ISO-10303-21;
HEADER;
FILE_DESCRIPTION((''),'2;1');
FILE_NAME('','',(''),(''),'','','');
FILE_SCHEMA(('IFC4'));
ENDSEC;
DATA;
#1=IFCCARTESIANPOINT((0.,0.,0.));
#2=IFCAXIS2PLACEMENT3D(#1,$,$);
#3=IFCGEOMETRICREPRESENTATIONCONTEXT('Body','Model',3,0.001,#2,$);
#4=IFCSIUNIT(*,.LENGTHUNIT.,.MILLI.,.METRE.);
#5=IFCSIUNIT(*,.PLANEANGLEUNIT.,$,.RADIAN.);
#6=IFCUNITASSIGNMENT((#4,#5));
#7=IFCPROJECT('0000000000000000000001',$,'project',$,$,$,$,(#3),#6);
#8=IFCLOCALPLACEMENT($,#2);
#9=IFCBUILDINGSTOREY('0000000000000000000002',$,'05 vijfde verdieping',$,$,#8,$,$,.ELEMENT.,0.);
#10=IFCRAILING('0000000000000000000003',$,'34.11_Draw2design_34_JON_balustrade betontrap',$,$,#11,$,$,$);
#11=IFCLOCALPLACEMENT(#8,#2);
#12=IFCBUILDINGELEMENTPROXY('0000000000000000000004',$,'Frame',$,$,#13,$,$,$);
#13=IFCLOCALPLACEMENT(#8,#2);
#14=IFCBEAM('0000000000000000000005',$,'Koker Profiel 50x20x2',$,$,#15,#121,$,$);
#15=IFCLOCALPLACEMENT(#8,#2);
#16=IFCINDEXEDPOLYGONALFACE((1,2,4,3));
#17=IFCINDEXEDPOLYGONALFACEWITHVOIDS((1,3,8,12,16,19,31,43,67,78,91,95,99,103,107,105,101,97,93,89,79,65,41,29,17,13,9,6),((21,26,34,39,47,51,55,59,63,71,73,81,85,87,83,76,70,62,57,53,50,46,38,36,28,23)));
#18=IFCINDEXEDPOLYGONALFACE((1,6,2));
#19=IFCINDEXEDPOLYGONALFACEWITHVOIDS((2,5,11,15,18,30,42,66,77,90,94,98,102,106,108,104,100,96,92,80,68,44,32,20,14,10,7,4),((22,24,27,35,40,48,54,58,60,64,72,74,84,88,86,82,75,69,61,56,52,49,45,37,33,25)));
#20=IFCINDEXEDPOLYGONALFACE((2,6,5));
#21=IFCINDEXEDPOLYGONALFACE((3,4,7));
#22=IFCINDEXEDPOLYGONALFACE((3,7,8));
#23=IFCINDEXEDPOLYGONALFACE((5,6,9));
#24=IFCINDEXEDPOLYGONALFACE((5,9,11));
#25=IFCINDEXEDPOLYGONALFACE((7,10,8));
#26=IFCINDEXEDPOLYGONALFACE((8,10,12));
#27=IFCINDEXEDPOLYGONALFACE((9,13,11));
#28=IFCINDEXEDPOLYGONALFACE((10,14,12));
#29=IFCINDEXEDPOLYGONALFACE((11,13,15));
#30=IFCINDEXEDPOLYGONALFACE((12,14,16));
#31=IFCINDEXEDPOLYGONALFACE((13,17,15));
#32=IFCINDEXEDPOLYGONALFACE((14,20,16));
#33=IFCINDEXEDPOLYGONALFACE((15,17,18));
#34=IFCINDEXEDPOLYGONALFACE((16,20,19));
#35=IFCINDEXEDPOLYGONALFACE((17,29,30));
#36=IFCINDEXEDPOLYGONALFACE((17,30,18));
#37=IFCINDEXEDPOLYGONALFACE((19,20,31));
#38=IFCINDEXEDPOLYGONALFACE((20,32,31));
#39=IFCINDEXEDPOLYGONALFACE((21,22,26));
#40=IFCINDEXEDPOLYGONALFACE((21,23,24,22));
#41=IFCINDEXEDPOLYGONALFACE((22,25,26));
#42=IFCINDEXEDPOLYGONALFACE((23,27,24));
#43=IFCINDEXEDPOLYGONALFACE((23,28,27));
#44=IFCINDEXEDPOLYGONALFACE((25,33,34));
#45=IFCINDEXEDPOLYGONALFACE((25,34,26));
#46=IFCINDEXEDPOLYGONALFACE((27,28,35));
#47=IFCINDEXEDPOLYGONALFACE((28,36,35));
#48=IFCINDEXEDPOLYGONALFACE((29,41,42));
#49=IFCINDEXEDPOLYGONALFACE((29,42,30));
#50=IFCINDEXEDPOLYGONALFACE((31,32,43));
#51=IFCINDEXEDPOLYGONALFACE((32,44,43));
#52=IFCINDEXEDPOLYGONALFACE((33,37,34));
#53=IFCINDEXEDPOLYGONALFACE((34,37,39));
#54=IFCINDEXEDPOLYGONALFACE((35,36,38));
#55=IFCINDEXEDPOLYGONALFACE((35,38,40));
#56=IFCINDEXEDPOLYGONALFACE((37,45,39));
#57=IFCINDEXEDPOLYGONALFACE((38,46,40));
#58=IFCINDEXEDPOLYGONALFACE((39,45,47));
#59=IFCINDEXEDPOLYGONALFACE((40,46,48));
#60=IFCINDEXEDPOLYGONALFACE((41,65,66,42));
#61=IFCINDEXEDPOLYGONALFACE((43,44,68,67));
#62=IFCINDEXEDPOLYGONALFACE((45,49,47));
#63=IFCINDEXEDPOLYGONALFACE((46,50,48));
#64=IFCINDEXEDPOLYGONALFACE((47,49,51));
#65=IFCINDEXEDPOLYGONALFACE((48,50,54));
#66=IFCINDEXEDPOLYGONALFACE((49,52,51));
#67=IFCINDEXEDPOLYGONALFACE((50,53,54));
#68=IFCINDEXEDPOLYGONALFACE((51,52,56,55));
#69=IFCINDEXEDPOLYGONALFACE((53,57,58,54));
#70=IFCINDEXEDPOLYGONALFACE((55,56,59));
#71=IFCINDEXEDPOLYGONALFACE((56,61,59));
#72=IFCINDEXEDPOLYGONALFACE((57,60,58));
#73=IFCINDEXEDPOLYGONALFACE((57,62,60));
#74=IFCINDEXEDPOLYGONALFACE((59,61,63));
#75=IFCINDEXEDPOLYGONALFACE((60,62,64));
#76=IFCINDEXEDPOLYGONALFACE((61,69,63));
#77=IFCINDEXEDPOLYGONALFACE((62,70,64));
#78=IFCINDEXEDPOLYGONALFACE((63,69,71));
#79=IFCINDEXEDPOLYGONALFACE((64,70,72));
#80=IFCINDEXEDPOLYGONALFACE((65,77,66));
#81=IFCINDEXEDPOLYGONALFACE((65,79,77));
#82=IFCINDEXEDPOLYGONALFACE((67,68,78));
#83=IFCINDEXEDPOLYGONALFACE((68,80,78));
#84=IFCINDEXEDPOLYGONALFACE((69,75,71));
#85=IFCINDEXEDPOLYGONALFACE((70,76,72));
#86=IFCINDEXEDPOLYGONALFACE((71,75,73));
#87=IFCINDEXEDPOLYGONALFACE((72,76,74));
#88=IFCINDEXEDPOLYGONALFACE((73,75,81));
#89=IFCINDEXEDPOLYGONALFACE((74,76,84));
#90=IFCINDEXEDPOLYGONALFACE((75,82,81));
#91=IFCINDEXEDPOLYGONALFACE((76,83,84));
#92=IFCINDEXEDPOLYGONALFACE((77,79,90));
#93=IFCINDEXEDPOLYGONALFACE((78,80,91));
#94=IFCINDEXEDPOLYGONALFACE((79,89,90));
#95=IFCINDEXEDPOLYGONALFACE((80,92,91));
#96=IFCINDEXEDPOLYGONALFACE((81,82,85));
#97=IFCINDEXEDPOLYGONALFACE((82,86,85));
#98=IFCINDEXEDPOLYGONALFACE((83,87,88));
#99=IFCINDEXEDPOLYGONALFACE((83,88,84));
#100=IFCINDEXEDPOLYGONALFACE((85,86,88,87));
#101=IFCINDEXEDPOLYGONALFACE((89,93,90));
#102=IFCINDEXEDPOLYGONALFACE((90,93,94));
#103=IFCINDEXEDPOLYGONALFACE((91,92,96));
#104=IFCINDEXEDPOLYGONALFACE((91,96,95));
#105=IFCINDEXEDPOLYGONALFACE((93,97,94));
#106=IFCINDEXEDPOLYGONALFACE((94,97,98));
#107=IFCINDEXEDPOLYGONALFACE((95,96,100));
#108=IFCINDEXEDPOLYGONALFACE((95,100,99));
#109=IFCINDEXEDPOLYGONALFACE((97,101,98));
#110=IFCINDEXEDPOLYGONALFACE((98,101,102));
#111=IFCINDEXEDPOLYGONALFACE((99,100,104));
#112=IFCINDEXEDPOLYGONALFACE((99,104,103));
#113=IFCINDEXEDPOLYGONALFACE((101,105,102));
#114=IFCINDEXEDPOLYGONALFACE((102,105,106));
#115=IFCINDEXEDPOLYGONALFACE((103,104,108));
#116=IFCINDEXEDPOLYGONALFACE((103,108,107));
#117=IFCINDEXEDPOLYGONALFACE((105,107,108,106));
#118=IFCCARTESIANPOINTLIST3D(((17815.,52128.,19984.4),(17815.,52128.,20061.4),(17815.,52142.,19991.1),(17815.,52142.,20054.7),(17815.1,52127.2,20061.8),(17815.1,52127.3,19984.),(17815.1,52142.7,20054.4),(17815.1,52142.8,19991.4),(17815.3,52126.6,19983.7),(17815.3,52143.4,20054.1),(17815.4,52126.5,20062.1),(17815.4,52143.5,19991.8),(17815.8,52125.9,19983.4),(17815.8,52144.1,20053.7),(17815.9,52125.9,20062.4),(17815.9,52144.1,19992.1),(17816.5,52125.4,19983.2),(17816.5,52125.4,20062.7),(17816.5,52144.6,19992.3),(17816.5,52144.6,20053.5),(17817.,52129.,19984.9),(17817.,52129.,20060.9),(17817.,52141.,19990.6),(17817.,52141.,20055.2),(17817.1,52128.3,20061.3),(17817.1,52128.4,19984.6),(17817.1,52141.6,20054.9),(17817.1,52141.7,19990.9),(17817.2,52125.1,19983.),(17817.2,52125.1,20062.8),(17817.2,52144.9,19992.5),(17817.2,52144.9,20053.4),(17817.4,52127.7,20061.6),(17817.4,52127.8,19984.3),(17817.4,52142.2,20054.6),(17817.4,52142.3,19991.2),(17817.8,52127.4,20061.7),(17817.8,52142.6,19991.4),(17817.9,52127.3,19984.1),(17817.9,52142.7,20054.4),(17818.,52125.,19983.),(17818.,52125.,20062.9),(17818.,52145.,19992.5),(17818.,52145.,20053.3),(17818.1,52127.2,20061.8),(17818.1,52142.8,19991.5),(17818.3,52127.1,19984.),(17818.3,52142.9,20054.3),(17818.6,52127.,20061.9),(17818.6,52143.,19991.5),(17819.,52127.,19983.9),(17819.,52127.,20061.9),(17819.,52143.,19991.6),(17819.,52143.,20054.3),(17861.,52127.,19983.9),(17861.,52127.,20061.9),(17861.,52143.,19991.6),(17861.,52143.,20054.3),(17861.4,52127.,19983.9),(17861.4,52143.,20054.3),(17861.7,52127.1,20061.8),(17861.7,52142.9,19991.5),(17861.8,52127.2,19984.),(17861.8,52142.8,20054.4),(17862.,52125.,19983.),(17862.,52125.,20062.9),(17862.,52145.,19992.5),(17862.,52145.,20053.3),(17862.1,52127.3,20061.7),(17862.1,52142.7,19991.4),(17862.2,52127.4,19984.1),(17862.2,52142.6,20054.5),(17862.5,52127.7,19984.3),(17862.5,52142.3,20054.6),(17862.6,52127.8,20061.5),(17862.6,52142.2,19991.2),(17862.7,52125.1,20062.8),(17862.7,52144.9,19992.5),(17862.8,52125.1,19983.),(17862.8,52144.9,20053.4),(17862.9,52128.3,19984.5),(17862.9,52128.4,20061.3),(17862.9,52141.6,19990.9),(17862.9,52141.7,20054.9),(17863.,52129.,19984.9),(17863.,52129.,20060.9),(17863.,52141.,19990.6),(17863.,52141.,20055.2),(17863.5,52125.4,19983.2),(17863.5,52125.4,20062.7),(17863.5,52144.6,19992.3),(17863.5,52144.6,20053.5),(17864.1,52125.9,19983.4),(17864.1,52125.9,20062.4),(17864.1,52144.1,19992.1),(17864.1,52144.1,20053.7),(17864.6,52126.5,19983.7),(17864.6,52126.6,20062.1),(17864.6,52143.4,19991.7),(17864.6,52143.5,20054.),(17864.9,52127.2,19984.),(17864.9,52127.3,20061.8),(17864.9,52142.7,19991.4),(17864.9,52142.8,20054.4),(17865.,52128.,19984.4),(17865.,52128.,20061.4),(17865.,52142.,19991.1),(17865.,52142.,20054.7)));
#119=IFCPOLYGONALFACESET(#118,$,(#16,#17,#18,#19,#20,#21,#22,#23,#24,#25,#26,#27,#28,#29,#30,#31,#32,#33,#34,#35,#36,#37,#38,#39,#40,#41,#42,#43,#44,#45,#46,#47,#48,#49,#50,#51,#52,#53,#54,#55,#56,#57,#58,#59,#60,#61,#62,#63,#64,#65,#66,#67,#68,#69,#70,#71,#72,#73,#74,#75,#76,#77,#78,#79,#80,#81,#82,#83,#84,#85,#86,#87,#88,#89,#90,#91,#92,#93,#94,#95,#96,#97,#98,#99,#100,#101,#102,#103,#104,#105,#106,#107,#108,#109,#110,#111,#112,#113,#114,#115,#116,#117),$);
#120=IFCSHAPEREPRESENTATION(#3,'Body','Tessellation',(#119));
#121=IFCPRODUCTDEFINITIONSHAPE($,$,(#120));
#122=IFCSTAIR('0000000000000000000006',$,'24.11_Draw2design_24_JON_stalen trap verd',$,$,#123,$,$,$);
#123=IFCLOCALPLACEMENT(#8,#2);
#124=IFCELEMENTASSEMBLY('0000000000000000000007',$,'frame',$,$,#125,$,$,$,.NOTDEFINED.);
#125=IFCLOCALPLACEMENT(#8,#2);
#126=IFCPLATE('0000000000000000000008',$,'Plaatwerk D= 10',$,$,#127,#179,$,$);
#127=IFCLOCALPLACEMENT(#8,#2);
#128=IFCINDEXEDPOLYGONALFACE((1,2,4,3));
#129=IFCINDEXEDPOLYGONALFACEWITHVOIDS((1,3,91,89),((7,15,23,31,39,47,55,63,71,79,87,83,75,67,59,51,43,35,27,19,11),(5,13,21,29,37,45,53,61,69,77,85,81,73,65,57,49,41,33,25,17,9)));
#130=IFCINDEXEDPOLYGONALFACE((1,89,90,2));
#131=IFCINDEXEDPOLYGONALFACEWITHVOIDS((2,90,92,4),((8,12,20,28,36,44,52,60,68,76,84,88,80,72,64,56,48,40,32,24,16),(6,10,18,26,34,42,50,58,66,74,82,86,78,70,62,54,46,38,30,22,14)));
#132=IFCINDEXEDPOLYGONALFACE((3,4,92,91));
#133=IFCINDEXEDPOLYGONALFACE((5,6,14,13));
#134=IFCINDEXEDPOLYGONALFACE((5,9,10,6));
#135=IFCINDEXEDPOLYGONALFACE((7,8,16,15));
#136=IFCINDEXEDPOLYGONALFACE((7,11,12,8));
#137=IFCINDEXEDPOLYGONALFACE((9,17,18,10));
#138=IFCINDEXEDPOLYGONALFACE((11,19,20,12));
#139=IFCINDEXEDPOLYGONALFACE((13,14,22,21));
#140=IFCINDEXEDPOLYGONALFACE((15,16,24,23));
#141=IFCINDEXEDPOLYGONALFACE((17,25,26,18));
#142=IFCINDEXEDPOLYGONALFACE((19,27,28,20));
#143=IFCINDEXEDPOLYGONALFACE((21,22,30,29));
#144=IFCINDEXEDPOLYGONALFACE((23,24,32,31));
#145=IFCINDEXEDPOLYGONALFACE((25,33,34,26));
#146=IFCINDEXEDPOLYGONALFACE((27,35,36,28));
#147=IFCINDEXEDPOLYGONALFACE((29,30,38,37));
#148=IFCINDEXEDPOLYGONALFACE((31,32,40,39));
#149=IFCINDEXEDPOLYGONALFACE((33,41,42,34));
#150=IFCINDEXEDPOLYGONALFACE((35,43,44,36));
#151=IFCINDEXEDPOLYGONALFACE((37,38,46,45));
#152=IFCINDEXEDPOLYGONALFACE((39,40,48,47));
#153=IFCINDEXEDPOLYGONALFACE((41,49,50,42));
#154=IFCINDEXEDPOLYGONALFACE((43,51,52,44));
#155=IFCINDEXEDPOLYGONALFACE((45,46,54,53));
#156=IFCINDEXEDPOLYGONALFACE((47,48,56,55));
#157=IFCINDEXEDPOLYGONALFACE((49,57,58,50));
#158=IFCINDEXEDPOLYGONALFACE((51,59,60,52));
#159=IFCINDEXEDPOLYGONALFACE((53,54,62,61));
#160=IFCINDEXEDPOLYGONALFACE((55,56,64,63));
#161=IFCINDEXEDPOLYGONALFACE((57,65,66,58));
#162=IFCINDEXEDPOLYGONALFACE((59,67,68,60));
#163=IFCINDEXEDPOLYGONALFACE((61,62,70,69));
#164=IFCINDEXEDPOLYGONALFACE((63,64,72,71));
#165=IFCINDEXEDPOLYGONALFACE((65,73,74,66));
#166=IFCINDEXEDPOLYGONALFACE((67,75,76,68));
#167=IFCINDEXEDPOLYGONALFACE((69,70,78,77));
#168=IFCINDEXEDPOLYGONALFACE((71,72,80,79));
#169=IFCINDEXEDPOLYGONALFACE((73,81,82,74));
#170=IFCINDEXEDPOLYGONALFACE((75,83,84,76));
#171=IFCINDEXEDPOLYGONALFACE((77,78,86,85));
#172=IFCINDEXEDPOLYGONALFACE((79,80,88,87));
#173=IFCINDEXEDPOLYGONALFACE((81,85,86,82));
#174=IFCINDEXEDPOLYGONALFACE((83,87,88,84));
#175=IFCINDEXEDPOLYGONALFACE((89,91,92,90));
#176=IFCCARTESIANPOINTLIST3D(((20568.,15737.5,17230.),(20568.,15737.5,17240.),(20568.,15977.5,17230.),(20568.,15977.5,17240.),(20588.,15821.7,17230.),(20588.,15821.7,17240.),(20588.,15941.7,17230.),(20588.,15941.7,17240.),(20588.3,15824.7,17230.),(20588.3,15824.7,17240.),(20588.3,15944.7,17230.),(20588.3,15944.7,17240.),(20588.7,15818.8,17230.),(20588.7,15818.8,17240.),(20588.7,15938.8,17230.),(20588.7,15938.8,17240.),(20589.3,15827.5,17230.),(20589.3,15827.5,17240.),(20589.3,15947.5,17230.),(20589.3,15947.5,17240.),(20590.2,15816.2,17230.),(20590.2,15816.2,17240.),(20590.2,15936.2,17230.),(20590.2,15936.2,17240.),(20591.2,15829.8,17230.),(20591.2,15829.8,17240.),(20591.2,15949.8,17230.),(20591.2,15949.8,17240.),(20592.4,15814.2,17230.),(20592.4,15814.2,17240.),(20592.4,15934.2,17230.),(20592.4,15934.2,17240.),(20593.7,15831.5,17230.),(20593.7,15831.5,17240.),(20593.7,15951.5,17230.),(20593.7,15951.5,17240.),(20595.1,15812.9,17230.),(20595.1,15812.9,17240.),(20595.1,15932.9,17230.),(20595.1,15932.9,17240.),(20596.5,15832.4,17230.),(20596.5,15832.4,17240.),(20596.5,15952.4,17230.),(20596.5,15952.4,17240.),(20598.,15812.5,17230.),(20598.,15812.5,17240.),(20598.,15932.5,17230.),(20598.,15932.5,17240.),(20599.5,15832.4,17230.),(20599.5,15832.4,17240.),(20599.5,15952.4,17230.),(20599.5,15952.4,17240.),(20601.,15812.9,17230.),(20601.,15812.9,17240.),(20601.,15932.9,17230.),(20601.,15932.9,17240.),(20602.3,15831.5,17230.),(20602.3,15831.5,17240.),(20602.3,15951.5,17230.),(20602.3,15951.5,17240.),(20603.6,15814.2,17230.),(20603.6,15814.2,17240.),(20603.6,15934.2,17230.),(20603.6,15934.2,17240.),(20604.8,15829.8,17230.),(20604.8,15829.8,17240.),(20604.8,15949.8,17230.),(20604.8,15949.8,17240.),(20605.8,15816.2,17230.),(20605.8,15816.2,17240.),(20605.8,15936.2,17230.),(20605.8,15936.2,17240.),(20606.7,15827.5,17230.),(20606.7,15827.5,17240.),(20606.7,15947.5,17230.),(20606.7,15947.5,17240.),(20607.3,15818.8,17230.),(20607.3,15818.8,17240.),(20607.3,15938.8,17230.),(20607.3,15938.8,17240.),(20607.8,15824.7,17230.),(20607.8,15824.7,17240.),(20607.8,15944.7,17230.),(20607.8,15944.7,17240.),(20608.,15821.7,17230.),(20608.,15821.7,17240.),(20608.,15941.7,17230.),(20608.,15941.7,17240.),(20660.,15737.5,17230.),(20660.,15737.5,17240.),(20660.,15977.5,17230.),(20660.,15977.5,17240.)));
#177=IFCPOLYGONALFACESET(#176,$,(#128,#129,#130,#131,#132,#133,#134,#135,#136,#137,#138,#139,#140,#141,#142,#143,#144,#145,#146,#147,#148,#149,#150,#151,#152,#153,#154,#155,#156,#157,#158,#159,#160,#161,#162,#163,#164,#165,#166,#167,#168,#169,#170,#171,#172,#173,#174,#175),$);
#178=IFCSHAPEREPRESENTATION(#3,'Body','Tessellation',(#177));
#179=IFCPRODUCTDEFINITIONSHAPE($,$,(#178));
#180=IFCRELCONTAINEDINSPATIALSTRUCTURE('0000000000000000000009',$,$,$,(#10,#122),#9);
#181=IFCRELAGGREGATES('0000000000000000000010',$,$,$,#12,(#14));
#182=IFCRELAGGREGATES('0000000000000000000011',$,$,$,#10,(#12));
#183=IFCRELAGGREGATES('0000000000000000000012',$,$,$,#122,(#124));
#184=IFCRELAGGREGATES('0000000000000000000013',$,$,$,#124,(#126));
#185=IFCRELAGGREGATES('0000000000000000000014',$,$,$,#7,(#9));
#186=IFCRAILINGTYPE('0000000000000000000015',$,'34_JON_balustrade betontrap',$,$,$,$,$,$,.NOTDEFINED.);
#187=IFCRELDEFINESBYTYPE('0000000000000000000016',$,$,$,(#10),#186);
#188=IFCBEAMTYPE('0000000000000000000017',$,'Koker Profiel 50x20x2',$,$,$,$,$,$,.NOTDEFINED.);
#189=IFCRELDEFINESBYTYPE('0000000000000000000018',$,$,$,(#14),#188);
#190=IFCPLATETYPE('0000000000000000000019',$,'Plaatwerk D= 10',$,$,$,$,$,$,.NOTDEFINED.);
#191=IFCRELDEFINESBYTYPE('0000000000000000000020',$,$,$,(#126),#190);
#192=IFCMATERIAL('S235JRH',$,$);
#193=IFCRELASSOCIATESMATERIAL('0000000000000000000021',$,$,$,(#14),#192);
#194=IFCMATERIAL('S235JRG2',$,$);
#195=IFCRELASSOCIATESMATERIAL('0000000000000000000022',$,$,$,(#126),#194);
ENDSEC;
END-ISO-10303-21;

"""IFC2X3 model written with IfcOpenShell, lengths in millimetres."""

from ifc_helpers import new_model, si_unit, frame, origin, origin_2d, place, context, project, spatial, rectangle, hollow_rectangle, circle, extrude, clip, halfspace, source, transform, mapped, material, type_object, element, aggregate, save


model = new_model("IFC2X3")

# Units and contexts
model_context = context("Model", 3, precision=0.001, world=origin(), identifier="Body")
ifc_project = project(units=[si_unit("LENGTHUNIT", "METRE", prefix="MILLI"), si_unit("PLANEANGLEUNIT", "RADIAN")], contexts=[model_context])

# Storey
storey_placement = place(None, origin())
storey = spatial("IfcBuildingStorey", under=ifc_project, at=storey_placement, Name="05 vijfde verdieping", CompositionType="ELEMENT", Elevation=0.0)

# Shared definitions
railing_type_1 = type_object("IfcRailingType", Name="34_JON_balustrade betontrap")
ifc_material_1 = material(Name="S235JRH")
ifc_material_2 = material(Name="S235JRG2")
beam_type_1 = type_object("IfcBeamType", Name="Koker Profiel 50x20x2")

# Railing, building element proxy
railing_1_placement = place(storey_placement, frame((38619.5, 98107.5, -28901.4), z_axis=(0.0, 0.0, 1.0), x_axis=(-1.0, 0.0, 0.0)))
railing_1 = element("IfcRailing", 1, at=railing_1_placement, inside=storey, type_object=railing_type_1, Name="34.11_Draw2design_34_JON_balustrade betontrap")
proxy_1_placement = place(railing_1_placement, origin())
proxy_1 = element("IfcBuildingElementProxy", 2, at=proxy_1_placement, Name="Frame")

# Beam
shared_shape_1 = source(origin(), model_context, "Body", "Clipping", [
    clip(clip(extrude(hollow_rectangle(XDim=20.0, YDim=50.0, WallThickness=2.0, InnerFilletRadius=2.0, OuterFilletRadius=3.0, at=origin_2d()), origin(), (0.0, 0.0, -1.0), 79.9), halfspace(frame((-10.0, 25.0, -9.6), z_axis=(-0.430948, 0.0, 0.902377), x_axis=(0.902377, 0.0, 0.430948)), False)), halfspace(frame((-10.0, -25.0, -70.3), z_axis=(-0.430948, 0.0, -0.902377), x_axis=(-0.902377, 0.0, 0.430948)), False)),
])
beam_1_placement = place(proxy_1_placement, frame((20779.5, 45972.5, 48964.2), z_axis=(0.0, 0.0, 1.0), x_axis=(0.0, 1.0, 0.0)))
beam_1 = element("IfcBeam", 3, at=beam_1_placement, type_object=beam_type_1, material=ifc_material_1, Name="Koker Profiel 50x20x2", context=model_context, shape_type="MappedRepresentation", body=[
    mapped(shared_shape_1, transform((0.0, 0.0, 0.0), scale=1.0)),
])
aggregate(proxy_1, [beam_1])

aggregate(railing_1, [proxy_1])

# Stair
stair_placement = place(storey_placement, frame((19764.0, 15957.5, 17488.2), z_axis=(0.0, 0.0, 1.0), x_axis=(0.0, -1.0, 0.0)))
stair = element("IfcStair", 4, at=stair_placement, inside=storey, Name="24.11_Draw2design_24_JON_stalen trap verd")

# Element assembly
assembly_placement = place(stair_placement, frame((0.0, 876.0, 0.0), z_axis=(0.0, 0.0, -1.0), x_axis=(1.0, 0.0, 0.0)))
assembly = element("IfcElementAssembly", 5, at=assembly_placement, Name="frame", PredefinedType="NOTDEFINED")
aggregate(stair, [assembly])

# Plate, openings
plate_type = type_object("IfcPlateType", Name="Plaatwerk D= 10")
shared_shape_2 = source(origin(), model_context, "Body", "SweptSolid", [
    extrude(rectangle(XDim=92.0, YDim=240.0, at=origin_2d()), frame((46.0, 0.0, -5.0)), (0.0, 0.0, 1.0), 10.0),
])
plate_1_placement = place(assembly_placement, frame((100.0, 72.0, 253.2), z_axis=(0.0, 0.0, 1.0), x_axis=(0.0, -1.0, 0.0)))
plate_1 = element("IfcPlate", 6, at=plate_1_placement, type_object=plate_type, material=ifc_material_2, Name="Plaatwerk D= 10", context=model_context, shape_type="MappedRepresentation", body=[
    mapped(shared_shape_2, transform((0.0, 0.0, 0.0), scale=1.0)),
])
opening_1_placement = place(plate_1_placement, frame((30.0, -85.0, 5.0), z_axis=(0.0, 0.0, -1.0), x_axis=(0.0, 1.0, 0.0)))
element("IfcOpeningElement", 7, at=opening_1_placement, cuts=plate_1, ObjectType="Opening", context=model_context, shape_type="SweptSolid", body=[
    extrude(circle(Radius=10.0, at=origin_2d()), origin(), (0.0, 0.0, 1.0), 10.0),
])
opening_2_placement = place(plate_1_placement, frame((30.0, 35.0, 5.0), z_axis=(0.0, 0.0, -1.0), x_axis=(0.0, 1.0, 0.0)))
element("IfcOpeningElement", 8, at=opening_2_placement, cuts=plate_1, ObjectType="Opening", context=model_context, shape_type="SweptSolid", body=[
    extrude(circle(Radius=10.0, at=origin_2d()), origin(), (0.0, 0.0, 1.0), 10.0),
])
aggregate(assembly, [plate_1])

save(model, "model.ifc")
